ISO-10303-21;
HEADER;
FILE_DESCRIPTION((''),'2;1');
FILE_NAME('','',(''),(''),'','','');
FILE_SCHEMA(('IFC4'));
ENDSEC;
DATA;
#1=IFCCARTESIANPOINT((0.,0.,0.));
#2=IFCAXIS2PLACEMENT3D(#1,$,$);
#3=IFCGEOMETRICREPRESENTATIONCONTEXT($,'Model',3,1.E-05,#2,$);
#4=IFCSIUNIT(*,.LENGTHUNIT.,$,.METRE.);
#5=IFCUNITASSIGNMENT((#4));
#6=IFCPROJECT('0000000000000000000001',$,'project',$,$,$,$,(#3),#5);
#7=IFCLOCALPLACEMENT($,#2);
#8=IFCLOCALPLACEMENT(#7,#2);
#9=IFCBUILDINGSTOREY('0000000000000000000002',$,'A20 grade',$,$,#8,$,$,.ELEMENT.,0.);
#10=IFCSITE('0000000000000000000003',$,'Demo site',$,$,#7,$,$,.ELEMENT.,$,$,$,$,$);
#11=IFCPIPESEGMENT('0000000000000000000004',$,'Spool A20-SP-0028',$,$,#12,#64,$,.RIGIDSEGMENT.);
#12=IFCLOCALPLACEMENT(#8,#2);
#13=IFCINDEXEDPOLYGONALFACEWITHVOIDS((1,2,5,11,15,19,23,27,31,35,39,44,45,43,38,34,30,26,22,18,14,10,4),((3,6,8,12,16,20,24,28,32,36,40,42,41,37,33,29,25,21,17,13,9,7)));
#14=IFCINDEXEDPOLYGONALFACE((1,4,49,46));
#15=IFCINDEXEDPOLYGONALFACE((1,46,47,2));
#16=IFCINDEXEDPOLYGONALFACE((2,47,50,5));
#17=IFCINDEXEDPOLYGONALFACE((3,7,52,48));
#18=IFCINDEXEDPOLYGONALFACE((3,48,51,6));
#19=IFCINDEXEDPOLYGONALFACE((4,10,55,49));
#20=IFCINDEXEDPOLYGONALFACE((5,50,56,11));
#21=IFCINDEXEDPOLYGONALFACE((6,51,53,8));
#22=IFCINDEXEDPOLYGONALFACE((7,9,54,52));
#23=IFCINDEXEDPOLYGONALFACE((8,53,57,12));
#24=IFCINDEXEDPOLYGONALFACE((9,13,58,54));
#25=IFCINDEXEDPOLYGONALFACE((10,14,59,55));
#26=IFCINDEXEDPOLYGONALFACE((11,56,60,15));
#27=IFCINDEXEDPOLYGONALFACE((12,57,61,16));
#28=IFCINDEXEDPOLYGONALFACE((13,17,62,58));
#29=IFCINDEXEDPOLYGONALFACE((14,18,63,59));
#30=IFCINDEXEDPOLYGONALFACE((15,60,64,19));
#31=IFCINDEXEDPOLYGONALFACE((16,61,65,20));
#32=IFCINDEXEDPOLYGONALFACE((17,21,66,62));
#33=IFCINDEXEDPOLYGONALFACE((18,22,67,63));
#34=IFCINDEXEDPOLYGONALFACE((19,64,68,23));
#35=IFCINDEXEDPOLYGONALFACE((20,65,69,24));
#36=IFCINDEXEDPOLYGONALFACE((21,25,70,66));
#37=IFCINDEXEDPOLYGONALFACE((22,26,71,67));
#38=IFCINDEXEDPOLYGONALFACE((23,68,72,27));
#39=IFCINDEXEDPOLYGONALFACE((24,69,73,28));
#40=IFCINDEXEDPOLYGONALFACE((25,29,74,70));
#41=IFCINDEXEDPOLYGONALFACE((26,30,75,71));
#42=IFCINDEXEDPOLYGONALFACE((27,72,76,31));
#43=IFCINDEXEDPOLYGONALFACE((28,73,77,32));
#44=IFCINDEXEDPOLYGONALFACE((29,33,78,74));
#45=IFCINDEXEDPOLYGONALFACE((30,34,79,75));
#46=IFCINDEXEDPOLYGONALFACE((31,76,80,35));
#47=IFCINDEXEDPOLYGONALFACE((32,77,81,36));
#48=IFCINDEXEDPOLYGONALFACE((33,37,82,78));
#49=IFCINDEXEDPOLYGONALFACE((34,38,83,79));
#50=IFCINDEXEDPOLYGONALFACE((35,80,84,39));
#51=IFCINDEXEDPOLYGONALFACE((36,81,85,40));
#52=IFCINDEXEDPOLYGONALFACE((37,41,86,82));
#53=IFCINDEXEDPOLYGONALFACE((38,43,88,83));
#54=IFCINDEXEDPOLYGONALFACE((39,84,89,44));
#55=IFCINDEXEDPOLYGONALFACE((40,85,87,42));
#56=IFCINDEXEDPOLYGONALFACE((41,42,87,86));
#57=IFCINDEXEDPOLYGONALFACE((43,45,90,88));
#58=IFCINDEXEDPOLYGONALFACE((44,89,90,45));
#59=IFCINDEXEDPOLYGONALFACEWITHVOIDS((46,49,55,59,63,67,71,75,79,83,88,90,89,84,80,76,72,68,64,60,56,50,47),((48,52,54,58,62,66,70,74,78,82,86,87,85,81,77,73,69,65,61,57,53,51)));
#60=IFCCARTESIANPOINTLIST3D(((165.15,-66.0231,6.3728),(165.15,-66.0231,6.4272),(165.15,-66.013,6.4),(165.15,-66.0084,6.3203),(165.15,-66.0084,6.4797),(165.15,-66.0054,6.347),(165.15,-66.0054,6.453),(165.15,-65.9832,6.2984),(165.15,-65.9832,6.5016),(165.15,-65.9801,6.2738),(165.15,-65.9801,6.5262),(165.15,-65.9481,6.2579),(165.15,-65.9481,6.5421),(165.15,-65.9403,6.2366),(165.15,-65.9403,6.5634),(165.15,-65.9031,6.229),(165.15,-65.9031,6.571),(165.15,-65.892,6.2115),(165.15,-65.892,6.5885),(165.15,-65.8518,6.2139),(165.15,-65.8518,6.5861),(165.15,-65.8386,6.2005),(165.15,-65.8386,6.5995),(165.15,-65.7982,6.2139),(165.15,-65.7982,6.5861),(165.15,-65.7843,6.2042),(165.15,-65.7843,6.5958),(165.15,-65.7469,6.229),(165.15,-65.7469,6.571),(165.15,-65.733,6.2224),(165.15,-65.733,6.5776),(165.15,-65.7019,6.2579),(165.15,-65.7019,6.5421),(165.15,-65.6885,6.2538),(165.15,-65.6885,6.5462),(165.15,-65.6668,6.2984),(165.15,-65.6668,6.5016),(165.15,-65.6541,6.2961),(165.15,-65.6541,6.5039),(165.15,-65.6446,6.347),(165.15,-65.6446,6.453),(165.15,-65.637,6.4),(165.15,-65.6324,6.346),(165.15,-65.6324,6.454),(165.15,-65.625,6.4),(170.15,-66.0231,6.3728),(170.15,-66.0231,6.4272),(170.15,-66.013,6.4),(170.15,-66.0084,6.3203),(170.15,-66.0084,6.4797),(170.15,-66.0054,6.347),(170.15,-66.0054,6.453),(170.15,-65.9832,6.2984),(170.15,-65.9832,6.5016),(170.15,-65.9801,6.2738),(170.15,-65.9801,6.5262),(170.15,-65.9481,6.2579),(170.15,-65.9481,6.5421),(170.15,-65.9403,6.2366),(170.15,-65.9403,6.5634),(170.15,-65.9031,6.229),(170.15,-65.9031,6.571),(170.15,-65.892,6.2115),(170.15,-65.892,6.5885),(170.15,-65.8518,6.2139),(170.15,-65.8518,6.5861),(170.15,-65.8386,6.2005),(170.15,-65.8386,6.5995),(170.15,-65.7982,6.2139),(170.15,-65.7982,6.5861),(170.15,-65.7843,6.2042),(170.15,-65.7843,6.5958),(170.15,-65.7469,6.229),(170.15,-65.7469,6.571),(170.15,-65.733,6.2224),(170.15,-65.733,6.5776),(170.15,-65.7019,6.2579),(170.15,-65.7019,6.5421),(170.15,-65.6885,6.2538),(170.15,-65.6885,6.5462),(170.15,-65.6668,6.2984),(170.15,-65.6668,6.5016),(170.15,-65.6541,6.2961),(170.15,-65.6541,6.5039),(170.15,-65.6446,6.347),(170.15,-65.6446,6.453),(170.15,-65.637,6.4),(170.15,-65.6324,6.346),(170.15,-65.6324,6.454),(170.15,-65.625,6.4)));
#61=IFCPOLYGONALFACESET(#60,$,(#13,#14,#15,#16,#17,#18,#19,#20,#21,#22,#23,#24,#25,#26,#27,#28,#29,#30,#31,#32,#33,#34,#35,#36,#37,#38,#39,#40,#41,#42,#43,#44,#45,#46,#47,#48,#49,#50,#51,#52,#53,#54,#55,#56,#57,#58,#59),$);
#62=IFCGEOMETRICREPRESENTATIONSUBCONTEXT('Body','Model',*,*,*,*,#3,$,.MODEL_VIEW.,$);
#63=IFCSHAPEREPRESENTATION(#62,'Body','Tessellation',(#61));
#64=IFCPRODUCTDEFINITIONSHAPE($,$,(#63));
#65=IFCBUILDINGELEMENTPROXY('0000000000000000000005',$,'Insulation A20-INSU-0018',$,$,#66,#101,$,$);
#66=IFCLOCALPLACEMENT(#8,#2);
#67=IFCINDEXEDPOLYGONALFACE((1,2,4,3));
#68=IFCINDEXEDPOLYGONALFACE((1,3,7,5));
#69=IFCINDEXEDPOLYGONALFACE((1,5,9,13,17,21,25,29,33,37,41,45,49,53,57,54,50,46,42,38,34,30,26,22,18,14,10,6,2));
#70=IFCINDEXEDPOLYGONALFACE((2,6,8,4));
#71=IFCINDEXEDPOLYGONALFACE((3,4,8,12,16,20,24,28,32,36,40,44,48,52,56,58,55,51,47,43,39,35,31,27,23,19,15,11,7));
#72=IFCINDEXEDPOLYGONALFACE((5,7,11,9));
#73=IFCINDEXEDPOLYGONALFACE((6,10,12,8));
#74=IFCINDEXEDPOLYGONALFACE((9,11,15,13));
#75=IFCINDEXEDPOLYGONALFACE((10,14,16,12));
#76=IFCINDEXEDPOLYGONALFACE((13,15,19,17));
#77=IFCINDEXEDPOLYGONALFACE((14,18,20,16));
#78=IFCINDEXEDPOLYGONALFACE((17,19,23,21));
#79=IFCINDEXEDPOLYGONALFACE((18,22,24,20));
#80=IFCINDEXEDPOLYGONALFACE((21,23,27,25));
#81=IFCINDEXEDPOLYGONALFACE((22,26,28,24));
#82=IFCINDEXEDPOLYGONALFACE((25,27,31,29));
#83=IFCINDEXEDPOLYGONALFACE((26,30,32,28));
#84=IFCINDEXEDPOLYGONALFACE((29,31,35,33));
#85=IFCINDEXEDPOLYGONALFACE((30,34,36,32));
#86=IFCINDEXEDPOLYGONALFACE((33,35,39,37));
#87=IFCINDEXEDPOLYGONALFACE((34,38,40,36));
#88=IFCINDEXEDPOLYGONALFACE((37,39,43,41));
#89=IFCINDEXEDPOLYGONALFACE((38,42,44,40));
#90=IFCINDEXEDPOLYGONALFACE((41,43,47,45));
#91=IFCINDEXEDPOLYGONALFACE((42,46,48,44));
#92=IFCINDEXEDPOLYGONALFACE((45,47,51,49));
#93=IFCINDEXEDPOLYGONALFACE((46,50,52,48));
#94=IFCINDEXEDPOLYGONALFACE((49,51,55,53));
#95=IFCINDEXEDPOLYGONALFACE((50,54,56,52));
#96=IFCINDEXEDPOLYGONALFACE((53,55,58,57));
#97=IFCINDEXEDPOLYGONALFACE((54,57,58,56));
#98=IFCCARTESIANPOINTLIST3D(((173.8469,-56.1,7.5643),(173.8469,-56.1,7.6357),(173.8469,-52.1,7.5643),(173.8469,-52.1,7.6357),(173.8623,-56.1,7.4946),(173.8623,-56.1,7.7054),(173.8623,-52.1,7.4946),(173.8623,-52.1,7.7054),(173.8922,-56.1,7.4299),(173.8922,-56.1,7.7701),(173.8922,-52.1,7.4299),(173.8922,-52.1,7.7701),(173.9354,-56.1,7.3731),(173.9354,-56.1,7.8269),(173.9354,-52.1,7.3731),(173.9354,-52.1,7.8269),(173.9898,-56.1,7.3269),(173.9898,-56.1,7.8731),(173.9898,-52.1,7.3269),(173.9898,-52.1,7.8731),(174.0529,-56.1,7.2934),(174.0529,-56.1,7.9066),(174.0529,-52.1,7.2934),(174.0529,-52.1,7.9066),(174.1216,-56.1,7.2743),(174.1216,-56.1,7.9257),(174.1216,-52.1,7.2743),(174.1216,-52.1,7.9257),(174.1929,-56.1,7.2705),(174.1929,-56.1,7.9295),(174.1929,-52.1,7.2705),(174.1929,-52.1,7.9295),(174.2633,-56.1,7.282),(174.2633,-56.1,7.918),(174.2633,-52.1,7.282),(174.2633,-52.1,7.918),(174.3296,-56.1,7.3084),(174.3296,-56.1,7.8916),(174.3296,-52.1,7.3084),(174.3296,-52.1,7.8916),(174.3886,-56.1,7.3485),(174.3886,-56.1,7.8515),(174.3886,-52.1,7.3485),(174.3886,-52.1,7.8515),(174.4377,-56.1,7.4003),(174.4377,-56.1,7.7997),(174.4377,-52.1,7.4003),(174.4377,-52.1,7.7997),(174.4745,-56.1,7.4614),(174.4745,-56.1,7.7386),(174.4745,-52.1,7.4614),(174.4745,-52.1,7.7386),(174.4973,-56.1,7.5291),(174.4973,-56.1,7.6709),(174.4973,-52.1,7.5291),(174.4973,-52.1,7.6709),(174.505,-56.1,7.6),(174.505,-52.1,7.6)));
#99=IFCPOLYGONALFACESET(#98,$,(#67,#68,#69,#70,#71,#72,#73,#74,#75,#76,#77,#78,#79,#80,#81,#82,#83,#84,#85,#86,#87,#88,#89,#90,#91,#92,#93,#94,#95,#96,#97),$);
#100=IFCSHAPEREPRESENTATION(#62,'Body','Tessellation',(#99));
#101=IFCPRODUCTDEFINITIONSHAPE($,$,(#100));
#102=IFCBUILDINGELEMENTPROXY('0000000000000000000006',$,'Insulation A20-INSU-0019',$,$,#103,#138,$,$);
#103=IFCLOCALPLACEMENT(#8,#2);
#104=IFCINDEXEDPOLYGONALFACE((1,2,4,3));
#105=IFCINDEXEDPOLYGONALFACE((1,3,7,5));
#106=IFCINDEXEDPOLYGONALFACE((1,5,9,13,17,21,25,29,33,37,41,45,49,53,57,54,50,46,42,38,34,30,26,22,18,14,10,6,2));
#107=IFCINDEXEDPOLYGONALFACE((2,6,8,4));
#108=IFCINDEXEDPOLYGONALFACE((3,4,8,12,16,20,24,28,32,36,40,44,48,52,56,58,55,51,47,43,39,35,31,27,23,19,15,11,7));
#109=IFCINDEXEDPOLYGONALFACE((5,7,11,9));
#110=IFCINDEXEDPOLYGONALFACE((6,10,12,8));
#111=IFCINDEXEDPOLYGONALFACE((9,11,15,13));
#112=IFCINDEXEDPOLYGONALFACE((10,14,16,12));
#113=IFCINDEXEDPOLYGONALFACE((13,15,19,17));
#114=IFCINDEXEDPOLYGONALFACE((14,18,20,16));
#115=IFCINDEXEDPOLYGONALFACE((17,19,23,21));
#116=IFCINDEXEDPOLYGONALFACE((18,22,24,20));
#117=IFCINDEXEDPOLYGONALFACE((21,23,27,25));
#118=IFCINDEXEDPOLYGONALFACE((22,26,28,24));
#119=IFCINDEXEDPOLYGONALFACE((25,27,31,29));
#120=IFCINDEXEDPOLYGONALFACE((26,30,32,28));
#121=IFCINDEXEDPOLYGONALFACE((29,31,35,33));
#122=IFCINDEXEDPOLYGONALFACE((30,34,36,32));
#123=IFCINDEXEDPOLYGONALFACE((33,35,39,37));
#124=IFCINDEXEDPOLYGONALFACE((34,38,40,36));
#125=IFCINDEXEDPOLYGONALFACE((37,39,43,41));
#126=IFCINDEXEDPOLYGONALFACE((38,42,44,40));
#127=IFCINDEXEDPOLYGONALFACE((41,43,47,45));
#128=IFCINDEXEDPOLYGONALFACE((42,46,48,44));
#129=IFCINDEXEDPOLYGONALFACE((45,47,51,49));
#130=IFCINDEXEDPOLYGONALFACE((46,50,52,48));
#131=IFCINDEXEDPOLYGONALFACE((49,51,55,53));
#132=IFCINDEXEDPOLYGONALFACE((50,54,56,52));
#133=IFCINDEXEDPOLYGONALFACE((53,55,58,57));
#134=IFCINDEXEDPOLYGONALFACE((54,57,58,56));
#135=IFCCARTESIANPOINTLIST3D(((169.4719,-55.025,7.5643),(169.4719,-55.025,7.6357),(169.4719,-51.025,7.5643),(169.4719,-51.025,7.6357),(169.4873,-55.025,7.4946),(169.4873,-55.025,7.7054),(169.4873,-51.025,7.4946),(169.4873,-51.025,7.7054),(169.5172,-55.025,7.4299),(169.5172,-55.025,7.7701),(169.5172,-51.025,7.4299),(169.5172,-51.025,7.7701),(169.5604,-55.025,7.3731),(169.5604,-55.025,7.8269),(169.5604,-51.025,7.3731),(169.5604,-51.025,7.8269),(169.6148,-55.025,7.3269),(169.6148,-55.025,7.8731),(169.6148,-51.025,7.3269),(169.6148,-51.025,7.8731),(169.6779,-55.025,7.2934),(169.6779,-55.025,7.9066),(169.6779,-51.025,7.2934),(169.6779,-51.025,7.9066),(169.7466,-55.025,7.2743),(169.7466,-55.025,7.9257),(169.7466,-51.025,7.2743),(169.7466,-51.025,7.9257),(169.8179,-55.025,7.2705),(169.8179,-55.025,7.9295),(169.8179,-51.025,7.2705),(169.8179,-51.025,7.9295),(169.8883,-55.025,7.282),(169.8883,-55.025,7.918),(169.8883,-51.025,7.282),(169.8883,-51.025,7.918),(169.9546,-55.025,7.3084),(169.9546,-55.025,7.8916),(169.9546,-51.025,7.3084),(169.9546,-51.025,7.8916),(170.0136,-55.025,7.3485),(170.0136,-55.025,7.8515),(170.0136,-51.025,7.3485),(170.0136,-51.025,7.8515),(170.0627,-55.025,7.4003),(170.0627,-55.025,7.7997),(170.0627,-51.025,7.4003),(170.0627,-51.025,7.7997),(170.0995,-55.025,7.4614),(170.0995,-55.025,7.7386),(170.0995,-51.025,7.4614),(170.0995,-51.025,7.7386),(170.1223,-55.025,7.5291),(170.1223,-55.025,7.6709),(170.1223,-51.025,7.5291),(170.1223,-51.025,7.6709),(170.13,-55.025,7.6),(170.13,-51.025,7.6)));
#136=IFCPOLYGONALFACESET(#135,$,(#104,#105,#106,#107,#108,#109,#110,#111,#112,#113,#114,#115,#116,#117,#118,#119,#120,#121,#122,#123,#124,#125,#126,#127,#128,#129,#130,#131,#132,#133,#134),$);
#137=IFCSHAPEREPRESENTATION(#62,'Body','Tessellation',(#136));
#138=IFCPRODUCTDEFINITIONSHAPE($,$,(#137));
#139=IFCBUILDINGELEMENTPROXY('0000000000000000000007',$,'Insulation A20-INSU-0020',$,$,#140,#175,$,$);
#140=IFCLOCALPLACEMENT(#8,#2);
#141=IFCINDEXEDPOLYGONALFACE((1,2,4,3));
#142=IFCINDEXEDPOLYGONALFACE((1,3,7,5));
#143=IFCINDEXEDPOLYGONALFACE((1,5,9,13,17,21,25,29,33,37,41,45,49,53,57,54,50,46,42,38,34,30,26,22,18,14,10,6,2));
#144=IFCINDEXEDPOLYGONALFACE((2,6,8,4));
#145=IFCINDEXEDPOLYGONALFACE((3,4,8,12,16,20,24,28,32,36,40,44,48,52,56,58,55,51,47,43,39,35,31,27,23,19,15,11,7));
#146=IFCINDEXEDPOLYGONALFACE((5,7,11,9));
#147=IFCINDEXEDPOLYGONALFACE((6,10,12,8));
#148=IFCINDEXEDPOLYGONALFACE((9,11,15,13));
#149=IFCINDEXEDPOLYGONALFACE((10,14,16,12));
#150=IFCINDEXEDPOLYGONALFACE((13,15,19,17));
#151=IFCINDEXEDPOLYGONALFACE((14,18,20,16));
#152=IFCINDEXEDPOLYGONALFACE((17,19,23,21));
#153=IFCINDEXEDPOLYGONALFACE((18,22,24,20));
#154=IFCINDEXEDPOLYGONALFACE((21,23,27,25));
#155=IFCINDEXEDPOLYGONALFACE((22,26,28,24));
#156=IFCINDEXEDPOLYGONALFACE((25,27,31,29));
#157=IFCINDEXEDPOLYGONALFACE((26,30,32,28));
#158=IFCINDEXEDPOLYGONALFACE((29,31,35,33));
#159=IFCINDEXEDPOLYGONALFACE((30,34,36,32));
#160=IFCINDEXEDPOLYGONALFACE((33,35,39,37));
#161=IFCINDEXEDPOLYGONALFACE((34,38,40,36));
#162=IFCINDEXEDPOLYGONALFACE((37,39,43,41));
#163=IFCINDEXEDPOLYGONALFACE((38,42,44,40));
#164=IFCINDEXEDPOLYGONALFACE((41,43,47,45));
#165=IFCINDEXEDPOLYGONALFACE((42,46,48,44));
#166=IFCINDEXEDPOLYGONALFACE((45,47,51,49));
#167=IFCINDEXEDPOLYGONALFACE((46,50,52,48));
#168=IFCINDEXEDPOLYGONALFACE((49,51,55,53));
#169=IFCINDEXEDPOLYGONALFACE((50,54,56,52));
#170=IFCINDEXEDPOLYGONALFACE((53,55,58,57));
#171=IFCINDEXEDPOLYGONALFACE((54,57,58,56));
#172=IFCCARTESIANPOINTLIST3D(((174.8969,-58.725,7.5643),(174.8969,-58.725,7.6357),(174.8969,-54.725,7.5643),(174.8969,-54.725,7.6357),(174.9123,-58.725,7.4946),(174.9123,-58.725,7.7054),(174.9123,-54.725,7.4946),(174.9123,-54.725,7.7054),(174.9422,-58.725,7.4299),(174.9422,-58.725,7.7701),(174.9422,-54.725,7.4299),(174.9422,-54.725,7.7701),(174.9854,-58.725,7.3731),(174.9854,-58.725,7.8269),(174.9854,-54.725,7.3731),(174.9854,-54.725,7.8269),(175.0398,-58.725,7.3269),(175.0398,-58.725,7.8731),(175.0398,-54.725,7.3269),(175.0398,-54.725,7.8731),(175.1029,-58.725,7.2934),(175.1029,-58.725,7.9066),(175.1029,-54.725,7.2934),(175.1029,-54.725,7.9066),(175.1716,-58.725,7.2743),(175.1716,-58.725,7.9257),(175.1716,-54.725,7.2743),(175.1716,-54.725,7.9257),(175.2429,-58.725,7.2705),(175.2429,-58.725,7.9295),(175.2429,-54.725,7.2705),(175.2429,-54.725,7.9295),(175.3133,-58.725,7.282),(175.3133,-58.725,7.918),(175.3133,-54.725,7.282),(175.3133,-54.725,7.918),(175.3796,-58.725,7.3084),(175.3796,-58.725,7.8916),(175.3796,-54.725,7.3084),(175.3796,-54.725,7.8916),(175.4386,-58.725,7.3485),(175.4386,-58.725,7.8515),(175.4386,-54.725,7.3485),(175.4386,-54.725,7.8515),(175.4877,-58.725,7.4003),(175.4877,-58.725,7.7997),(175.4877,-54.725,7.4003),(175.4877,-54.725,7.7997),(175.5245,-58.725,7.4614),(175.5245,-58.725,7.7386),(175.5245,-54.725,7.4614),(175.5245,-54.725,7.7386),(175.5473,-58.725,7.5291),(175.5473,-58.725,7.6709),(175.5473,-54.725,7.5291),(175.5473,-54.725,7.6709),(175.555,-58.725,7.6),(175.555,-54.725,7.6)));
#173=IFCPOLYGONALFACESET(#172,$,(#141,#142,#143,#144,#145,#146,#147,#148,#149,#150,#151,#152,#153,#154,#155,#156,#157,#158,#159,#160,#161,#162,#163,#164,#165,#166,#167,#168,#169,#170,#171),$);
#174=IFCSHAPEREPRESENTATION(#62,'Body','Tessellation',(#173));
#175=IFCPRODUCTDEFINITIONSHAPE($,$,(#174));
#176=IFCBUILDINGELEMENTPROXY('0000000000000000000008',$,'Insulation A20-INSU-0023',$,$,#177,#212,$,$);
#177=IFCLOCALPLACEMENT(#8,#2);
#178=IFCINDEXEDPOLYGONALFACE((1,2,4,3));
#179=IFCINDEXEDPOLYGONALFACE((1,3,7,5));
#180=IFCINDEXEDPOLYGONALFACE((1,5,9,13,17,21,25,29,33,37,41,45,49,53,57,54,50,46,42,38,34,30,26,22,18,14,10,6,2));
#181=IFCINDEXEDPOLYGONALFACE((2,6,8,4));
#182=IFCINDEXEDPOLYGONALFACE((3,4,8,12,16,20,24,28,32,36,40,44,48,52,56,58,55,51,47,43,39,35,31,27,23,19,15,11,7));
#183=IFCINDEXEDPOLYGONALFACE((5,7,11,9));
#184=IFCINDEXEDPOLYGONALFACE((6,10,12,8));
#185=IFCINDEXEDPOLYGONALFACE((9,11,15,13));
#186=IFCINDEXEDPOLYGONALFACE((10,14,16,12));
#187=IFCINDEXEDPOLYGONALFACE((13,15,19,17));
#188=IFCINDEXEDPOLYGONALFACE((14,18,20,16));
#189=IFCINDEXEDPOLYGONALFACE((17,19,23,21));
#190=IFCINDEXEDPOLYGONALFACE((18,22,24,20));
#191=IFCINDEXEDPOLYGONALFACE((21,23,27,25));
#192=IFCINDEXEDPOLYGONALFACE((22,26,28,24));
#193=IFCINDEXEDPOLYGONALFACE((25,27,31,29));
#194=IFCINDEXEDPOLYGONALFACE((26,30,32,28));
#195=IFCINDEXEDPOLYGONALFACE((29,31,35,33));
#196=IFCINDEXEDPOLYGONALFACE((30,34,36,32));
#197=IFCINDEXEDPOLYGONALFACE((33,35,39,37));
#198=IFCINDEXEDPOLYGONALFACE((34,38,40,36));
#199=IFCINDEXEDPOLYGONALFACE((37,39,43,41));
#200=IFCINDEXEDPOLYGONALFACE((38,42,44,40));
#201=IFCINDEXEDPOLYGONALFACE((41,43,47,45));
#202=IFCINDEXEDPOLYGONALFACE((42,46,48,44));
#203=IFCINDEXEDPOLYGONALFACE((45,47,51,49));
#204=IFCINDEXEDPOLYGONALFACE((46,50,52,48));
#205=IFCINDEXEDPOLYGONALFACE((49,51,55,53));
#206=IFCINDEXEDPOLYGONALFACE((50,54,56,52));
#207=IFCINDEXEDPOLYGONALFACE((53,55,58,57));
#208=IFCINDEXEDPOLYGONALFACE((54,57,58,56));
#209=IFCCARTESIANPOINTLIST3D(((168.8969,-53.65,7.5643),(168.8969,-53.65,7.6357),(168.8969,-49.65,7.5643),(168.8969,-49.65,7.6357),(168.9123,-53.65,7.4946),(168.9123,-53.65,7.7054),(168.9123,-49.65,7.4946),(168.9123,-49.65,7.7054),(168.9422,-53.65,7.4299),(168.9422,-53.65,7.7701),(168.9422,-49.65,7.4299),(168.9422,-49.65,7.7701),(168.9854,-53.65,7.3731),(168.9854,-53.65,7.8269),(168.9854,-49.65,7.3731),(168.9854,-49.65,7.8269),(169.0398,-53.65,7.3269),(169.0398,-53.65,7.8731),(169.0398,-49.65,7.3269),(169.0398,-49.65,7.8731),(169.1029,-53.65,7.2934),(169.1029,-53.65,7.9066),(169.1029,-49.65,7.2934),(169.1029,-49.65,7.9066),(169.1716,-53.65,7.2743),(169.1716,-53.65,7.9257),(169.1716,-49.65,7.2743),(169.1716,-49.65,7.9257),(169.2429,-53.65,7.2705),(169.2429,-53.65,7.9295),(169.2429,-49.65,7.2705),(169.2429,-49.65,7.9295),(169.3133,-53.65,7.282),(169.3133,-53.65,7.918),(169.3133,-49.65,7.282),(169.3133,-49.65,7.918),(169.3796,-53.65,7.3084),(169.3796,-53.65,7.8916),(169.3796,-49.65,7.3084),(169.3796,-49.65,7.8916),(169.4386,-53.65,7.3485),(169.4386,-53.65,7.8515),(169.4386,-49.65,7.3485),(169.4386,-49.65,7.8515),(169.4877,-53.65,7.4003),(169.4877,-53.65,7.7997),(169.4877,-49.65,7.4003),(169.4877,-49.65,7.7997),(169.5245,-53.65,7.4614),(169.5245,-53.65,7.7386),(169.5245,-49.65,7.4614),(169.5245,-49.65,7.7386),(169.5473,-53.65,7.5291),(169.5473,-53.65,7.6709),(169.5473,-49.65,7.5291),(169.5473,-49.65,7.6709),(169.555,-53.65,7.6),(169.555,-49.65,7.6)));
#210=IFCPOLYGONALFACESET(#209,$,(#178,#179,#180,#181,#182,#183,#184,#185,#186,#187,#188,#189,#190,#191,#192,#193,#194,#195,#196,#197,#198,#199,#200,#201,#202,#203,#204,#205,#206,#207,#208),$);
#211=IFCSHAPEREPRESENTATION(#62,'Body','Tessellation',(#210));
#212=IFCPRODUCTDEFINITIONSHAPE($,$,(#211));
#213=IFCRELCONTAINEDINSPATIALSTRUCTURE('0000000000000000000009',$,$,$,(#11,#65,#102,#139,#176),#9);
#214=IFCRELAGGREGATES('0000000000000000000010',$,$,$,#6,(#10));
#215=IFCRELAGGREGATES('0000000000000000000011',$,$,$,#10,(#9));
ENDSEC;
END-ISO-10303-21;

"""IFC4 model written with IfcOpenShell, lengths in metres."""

from ifc_helpers import new_model, si_unit, frame, origin, place, context, subcontext, project, spatial, circle, hollow_circle, extrude, element, save


model = new_model("IFC4")

# Units and contexts
model_context = context("Model", 3, precision=1e-05, world=origin())
body_context = subcontext(model_context, "Body", "Model", "MODEL_VIEW")
ifc_project = project(units=[si_unit("LENGTHUNIT", "METRE")], contexts=[model_context])

# Site, storey
site_placement = place(None, origin())
site = spatial("IfcSite", under=ifc_project, at=site_placement, Name="Demo site", CompositionType="ELEMENT")
storey_placement = place(site_placement, origin())
storey = spatial("IfcBuildingStorey", under=site, at=storey_placement, Name="A20 grade", CompositionType="ELEMENT", Elevation=0.0)

# Pipe segment
pipe_segment_1_placement = place(storey_placement, frame((165.15, -65.825, 6.4)))
element("IfcPipeSegment", 1, at=pipe_segment_1_placement, inside=storey, Name="Spool A20-SP-0028", PredefinedType="RIGIDSEGMENT", context=body_context, shape_type="SweptSolid", body=[
    extrude(hollow_circle(Radius=0.2, WallThickness=0.012), frame((0.0, 0.0, 0.0), z_axis=(1.0, 0.0, 0.0), x_axis=(0.0, 1.0, 0.0)), (0.0, 0.0, 1.0), 5.0),
])

# Building element proxies
for number, where, name in (
    (2, (174.175, -56.1, 7.6), "Insulation A20-INSU-0018"),
    (3, (169.8, -55.025, 7.6), "Insulation A20-INSU-0019"),
    (4, (175.225, -58.725, 7.6), "Insulation A20-INSU-0020"),
    (5, (169.225, -53.65, 7.6), "Insulation A20-INSU-0023"),
):
    element("IfcBuildingElementProxy", number, at=place(storey_placement, frame(where)), inside=storey, Name=name, context=body_context, shape_type="SweptSolid", body=[
        extrude(circle(Radius=0.33), frame((0.0, 0.0, 0.0), z_axis=(0.0, 1.0, 0.0), x_axis=(1.0, 0.0, 0.0)), (0.0, 0.0, 1.0), 4.0),
    ])

save(model, "model.ifc")
